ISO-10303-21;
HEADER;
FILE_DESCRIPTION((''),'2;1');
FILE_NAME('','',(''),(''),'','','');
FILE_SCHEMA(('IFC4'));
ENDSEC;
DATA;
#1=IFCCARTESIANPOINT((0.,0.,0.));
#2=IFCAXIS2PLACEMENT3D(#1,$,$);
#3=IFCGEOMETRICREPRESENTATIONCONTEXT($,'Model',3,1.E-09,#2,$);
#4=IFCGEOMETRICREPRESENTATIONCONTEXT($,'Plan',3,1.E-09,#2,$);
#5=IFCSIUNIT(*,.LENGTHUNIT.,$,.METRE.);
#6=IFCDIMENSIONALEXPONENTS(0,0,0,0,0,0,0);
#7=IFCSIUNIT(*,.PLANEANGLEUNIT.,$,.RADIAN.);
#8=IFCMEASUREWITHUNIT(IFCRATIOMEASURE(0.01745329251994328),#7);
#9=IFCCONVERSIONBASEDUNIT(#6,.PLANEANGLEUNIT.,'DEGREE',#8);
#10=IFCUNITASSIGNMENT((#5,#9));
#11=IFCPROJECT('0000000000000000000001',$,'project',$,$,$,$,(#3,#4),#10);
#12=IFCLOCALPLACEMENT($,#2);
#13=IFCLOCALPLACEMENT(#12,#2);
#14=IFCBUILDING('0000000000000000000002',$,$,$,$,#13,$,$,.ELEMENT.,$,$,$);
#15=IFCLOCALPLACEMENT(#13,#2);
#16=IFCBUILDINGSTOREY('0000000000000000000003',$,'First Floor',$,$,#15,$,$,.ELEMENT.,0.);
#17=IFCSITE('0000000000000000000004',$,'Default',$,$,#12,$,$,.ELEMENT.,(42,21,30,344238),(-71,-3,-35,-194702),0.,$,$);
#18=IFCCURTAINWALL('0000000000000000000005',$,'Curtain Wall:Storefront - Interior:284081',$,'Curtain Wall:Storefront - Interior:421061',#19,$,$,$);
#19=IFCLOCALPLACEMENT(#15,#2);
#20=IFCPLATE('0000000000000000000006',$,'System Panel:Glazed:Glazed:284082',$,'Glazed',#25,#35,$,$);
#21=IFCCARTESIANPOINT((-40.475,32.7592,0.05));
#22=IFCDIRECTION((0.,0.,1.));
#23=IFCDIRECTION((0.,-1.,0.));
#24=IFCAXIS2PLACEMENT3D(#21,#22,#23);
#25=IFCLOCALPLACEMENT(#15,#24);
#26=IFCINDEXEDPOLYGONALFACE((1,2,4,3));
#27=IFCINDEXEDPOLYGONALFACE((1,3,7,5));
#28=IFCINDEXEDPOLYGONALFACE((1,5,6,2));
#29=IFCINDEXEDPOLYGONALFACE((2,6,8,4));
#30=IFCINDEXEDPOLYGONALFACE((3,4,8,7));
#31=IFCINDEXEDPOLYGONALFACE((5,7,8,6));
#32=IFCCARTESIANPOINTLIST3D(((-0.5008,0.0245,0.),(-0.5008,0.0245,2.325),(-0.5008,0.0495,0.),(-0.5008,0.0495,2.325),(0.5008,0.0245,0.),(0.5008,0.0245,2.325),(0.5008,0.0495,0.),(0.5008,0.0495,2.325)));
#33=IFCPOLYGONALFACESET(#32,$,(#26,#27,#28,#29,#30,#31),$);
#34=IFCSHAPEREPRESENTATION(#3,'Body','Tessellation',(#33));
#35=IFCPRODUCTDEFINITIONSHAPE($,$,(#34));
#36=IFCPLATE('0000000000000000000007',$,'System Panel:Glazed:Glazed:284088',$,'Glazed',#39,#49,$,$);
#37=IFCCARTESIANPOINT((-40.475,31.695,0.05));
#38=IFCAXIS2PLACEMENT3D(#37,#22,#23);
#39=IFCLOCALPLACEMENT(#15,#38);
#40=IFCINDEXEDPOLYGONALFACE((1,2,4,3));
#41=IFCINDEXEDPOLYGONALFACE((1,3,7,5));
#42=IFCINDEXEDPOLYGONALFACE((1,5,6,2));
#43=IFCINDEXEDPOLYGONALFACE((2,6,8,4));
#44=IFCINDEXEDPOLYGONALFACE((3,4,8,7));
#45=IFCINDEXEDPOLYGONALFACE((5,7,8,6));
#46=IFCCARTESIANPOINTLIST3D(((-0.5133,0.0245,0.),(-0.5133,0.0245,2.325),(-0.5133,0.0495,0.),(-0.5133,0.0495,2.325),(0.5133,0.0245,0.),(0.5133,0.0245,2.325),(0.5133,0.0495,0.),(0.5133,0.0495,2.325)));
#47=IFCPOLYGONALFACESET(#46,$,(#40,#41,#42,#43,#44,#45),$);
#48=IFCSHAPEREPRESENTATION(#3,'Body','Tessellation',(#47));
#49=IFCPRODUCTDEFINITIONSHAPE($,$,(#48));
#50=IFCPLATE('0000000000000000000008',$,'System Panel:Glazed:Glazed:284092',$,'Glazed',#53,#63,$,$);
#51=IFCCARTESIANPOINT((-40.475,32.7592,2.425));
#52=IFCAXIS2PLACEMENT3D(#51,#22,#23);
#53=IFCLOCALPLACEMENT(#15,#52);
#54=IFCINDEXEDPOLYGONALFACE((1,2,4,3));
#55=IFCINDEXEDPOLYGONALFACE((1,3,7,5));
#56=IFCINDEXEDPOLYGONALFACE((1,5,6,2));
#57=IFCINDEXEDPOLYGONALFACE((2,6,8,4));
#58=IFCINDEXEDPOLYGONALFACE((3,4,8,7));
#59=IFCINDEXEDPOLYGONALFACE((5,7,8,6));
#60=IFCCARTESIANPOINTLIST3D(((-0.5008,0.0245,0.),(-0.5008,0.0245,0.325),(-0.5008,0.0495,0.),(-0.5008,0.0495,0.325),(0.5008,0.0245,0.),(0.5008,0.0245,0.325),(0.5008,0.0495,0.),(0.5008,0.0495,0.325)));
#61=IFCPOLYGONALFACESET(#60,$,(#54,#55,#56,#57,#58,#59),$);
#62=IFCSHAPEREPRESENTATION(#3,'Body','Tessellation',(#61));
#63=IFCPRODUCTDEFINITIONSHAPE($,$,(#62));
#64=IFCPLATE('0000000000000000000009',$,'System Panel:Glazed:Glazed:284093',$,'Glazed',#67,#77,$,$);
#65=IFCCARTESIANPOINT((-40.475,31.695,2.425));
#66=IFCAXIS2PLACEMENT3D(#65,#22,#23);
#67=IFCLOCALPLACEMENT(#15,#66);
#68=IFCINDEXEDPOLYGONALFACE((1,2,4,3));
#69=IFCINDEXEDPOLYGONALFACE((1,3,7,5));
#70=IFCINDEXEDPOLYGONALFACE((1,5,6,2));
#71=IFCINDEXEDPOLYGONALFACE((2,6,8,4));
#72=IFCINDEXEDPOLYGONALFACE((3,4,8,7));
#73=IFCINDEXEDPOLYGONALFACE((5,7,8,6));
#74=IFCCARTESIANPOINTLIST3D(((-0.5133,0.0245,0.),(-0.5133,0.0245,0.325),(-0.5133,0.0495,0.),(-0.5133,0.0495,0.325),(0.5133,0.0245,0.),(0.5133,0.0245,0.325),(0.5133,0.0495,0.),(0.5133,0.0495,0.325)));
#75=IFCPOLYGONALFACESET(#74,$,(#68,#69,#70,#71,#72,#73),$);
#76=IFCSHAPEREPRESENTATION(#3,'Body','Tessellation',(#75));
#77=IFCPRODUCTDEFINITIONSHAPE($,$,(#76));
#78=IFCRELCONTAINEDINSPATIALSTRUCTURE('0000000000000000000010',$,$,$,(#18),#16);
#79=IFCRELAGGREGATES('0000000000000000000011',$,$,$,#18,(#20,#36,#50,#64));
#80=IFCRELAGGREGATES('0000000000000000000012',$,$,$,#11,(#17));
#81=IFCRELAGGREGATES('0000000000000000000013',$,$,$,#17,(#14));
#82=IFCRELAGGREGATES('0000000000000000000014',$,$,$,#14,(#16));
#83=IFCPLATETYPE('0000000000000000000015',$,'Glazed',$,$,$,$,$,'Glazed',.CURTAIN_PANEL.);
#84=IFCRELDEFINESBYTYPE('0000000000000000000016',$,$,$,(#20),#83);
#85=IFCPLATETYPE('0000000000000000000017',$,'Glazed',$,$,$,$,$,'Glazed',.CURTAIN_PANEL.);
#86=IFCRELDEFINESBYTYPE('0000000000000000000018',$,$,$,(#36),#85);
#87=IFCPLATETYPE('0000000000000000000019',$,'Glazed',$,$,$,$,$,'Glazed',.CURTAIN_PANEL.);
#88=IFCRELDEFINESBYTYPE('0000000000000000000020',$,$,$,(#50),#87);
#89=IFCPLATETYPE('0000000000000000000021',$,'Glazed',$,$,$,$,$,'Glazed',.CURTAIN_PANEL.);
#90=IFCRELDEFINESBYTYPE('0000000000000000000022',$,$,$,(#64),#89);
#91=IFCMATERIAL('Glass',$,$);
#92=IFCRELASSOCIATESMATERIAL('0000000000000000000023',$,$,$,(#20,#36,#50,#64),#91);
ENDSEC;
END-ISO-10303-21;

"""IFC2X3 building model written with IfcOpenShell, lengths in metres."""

from ifc_helpers import new_model, entity, si_unit, converted_unit, frame, origin, origin_2d_with_axis, place, context, project, spatial, rectangle, extrude, source, transform, mapped, material, type_object, type_shapes, element, aggregate, save


model = new_model("IFC2X3")

# Units and contexts
model_context = context("Model", 3, precision=1e-09, world=origin())
plan_context = context("Plan", 3, precision=1e-09, world=origin())
ifc_project = project(units=[si_unit("LENGTHUNIT", "METRE"), converted_unit("PLANEANGLEUNIT", "DEGREE", entity("IfcRatioMeasure", 0.01745329251994328), si_unit("PLANEANGLEUNIT", "RADIAN"), dimensions=[0, 0, 0, 0, 0, 0, 0])], contexts=[model_context, plan_context])

# Site, building, storey
site_placement = place(None, origin())
site = spatial("IfcSite", under=ifc_project, at=site_placement, Name="Default", CompositionType="ELEMENT", RefLatitude=(42, 21, 30, 344238), RefLongitude=(-71, -3, -35, -194702), RefElevation=0.0)
building_placement = place(site_placement, origin())
building = spatial("IfcBuilding", under=site, at=building_placement, CompositionType="ELEMENT")
storey_placement = place(building_placement, origin())
storey = spatial("IfcBuildingStorey", under=building, at=storey_placement, Name="First Floor", CompositionType="ELEMENT", Elevation=0.0)

# Curtain wall, plates
curtain_wall_placement = place(storey_placement, origin())
curtain_wall = element("IfcCurtainWall", 1, at=curtain_wall_placement, inside=storey, Name="Curtain Wall:Storefront - Interior:284081", ObjectType="Curtain Wall:Storefront - Interior:421061")
ifc_material_1 = material(Name="Glass")
plate_type_1 = type_object("IfcPlateType", Name="Glazed", ElementType="Glazed", PredefinedType="CURTAIN_PANEL")
shared_shape_1 = source(origin(), model_context, "Body", "SweptSolid", [
    extrude(rectangle(XDim=0.025, YDim=1.0017, at=origin_2d_with_axis()), frame((0.0, 0.037, 0.0), z_axis=(0.0, 0.0, 1.0), x_axis=(0.0, 1.0, 0.0)), (0.0, 0.0, 1.0), 2.325),
])
type_shapes(plate_type_1, [shared_shape_1])
plate_1_placement = place(storey_placement, frame((-40.475, 32.7592, 0.05), z_axis=(0.0, 0.0, 1.0), x_axis=(0.0, -1.0, 0.0)))
plate_1 = element("IfcPlate", 2, at=plate_1_placement, type_object=plate_type_1, material=ifc_material_1, Name="System Panel:Glazed:Glazed:284082", ObjectType="Glazed", context=model_context, shape_type="MappedRepresentation", body=[
    mapped(shared_shape_1, transform((0.0, 0.0, 0.0), scale=1.0)),
])
plate_type_2 = type_object("IfcPlateType", Name="Glazed", ElementType="Glazed", PredefinedType="CURTAIN_PANEL")
shared_shape_2 = source(origin(), model_context, "Body", "SweptSolid", [
    extrude(rectangle(XDim=0.025, YDim=1.0267, at=origin_2d_with_axis()), frame((0.0, 0.037, 0.0), z_axis=(0.0, 0.0, 1.0), x_axis=(0.0, 1.0, 0.0)), (0.0, 0.0, 1.0), 2.325),
])
type_shapes(plate_type_2, [shared_shape_2])
plate_2_placement = place(storey_placement, frame((-40.475, 31.695, 0.05), z_axis=(0.0, 0.0, 1.0), x_axis=(0.0, -1.0, 0.0)))
plate_2 = element("IfcPlate", 3, at=plate_2_placement, type_object=plate_type_2, material=ifc_material_1, Name="System Panel:Glazed:Glazed:284088", ObjectType="Glazed", context=model_context, shape_type="MappedRepresentation", body=[
    mapped(shared_shape_2, transform((0.0, 0.0, 0.0), scale=1.0)),
])
plate_type_3 = type_object("IfcPlateType", Name="Glazed", ElementType="Glazed", PredefinedType="CURTAIN_PANEL")
shared_shape_3 = source(origin(), model_context, "Body", "SweptSolid", [
    extrude(rectangle(XDim=0.025, YDim=1.0017, at=origin_2d_with_axis()), frame((0.0, 0.037, 0.0), z_axis=(0.0, 0.0, 1.0), x_axis=(0.0, 1.0, 0.0)), (0.0, 0.0, 1.0), 0.325),
])
type_shapes(plate_type_3, [shared_shape_3])
plate_3_placement = place(storey_placement, frame((-40.475, 32.7592, 2.425), z_axis=(0.0, 0.0, 1.0), x_axis=(0.0, -1.0, 0.0)))
plate_3 = element("IfcPlate", 4, at=plate_3_placement, type_object=plate_type_3, material=ifc_material_1, Name="System Panel:Glazed:Glazed:284092", ObjectType="Glazed", context=model_context, shape_type="MappedRepresentation", body=[
    mapped(shared_shape_3, transform((0.0, 0.0, 0.0), scale=1.0)),
])
plate_type_4 = type_object("IfcPlateType", Name="Glazed", ElementType="Glazed", PredefinedType="CURTAIN_PANEL")
shared_shape_4 = source(origin(), model_context, "Body", "SweptSolid", [
    extrude(rectangle(XDim=0.025, YDim=1.0267, at=origin_2d_with_axis()), frame((0.0, 0.037, 0.0), z_axis=(0.0, 0.0, 1.0), x_axis=(0.0, 1.0, 0.0)), (0.0, 0.0, 1.0), 0.325),
])
type_shapes(plate_type_4, [shared_shape_4])
plate_4_placement = place(storey_placement, frame((-40.475, 31.695, 2.425), z_axis=(0.0, 0.0, 1.0), x_axis=(0.0, -1.0, 0.0)))
plate_4 = element("IfcPlate", 5, at=plate_4_placement, type_object=plate_type_4, material=ifc_material_1, Name="System Panel:Glazed:Glazed:284093", ObjectType="Glazed", context=model_context, shape_type="MappedRepresentation", body=[
    mapped(shared_shape_4, transform((0.0, 0.0, 0.0), scale=1.0)),
])
aggregate(curtain_wall, [plate_1, plate_2, plate_3, plate_4])

save(model, "model.ifc")
